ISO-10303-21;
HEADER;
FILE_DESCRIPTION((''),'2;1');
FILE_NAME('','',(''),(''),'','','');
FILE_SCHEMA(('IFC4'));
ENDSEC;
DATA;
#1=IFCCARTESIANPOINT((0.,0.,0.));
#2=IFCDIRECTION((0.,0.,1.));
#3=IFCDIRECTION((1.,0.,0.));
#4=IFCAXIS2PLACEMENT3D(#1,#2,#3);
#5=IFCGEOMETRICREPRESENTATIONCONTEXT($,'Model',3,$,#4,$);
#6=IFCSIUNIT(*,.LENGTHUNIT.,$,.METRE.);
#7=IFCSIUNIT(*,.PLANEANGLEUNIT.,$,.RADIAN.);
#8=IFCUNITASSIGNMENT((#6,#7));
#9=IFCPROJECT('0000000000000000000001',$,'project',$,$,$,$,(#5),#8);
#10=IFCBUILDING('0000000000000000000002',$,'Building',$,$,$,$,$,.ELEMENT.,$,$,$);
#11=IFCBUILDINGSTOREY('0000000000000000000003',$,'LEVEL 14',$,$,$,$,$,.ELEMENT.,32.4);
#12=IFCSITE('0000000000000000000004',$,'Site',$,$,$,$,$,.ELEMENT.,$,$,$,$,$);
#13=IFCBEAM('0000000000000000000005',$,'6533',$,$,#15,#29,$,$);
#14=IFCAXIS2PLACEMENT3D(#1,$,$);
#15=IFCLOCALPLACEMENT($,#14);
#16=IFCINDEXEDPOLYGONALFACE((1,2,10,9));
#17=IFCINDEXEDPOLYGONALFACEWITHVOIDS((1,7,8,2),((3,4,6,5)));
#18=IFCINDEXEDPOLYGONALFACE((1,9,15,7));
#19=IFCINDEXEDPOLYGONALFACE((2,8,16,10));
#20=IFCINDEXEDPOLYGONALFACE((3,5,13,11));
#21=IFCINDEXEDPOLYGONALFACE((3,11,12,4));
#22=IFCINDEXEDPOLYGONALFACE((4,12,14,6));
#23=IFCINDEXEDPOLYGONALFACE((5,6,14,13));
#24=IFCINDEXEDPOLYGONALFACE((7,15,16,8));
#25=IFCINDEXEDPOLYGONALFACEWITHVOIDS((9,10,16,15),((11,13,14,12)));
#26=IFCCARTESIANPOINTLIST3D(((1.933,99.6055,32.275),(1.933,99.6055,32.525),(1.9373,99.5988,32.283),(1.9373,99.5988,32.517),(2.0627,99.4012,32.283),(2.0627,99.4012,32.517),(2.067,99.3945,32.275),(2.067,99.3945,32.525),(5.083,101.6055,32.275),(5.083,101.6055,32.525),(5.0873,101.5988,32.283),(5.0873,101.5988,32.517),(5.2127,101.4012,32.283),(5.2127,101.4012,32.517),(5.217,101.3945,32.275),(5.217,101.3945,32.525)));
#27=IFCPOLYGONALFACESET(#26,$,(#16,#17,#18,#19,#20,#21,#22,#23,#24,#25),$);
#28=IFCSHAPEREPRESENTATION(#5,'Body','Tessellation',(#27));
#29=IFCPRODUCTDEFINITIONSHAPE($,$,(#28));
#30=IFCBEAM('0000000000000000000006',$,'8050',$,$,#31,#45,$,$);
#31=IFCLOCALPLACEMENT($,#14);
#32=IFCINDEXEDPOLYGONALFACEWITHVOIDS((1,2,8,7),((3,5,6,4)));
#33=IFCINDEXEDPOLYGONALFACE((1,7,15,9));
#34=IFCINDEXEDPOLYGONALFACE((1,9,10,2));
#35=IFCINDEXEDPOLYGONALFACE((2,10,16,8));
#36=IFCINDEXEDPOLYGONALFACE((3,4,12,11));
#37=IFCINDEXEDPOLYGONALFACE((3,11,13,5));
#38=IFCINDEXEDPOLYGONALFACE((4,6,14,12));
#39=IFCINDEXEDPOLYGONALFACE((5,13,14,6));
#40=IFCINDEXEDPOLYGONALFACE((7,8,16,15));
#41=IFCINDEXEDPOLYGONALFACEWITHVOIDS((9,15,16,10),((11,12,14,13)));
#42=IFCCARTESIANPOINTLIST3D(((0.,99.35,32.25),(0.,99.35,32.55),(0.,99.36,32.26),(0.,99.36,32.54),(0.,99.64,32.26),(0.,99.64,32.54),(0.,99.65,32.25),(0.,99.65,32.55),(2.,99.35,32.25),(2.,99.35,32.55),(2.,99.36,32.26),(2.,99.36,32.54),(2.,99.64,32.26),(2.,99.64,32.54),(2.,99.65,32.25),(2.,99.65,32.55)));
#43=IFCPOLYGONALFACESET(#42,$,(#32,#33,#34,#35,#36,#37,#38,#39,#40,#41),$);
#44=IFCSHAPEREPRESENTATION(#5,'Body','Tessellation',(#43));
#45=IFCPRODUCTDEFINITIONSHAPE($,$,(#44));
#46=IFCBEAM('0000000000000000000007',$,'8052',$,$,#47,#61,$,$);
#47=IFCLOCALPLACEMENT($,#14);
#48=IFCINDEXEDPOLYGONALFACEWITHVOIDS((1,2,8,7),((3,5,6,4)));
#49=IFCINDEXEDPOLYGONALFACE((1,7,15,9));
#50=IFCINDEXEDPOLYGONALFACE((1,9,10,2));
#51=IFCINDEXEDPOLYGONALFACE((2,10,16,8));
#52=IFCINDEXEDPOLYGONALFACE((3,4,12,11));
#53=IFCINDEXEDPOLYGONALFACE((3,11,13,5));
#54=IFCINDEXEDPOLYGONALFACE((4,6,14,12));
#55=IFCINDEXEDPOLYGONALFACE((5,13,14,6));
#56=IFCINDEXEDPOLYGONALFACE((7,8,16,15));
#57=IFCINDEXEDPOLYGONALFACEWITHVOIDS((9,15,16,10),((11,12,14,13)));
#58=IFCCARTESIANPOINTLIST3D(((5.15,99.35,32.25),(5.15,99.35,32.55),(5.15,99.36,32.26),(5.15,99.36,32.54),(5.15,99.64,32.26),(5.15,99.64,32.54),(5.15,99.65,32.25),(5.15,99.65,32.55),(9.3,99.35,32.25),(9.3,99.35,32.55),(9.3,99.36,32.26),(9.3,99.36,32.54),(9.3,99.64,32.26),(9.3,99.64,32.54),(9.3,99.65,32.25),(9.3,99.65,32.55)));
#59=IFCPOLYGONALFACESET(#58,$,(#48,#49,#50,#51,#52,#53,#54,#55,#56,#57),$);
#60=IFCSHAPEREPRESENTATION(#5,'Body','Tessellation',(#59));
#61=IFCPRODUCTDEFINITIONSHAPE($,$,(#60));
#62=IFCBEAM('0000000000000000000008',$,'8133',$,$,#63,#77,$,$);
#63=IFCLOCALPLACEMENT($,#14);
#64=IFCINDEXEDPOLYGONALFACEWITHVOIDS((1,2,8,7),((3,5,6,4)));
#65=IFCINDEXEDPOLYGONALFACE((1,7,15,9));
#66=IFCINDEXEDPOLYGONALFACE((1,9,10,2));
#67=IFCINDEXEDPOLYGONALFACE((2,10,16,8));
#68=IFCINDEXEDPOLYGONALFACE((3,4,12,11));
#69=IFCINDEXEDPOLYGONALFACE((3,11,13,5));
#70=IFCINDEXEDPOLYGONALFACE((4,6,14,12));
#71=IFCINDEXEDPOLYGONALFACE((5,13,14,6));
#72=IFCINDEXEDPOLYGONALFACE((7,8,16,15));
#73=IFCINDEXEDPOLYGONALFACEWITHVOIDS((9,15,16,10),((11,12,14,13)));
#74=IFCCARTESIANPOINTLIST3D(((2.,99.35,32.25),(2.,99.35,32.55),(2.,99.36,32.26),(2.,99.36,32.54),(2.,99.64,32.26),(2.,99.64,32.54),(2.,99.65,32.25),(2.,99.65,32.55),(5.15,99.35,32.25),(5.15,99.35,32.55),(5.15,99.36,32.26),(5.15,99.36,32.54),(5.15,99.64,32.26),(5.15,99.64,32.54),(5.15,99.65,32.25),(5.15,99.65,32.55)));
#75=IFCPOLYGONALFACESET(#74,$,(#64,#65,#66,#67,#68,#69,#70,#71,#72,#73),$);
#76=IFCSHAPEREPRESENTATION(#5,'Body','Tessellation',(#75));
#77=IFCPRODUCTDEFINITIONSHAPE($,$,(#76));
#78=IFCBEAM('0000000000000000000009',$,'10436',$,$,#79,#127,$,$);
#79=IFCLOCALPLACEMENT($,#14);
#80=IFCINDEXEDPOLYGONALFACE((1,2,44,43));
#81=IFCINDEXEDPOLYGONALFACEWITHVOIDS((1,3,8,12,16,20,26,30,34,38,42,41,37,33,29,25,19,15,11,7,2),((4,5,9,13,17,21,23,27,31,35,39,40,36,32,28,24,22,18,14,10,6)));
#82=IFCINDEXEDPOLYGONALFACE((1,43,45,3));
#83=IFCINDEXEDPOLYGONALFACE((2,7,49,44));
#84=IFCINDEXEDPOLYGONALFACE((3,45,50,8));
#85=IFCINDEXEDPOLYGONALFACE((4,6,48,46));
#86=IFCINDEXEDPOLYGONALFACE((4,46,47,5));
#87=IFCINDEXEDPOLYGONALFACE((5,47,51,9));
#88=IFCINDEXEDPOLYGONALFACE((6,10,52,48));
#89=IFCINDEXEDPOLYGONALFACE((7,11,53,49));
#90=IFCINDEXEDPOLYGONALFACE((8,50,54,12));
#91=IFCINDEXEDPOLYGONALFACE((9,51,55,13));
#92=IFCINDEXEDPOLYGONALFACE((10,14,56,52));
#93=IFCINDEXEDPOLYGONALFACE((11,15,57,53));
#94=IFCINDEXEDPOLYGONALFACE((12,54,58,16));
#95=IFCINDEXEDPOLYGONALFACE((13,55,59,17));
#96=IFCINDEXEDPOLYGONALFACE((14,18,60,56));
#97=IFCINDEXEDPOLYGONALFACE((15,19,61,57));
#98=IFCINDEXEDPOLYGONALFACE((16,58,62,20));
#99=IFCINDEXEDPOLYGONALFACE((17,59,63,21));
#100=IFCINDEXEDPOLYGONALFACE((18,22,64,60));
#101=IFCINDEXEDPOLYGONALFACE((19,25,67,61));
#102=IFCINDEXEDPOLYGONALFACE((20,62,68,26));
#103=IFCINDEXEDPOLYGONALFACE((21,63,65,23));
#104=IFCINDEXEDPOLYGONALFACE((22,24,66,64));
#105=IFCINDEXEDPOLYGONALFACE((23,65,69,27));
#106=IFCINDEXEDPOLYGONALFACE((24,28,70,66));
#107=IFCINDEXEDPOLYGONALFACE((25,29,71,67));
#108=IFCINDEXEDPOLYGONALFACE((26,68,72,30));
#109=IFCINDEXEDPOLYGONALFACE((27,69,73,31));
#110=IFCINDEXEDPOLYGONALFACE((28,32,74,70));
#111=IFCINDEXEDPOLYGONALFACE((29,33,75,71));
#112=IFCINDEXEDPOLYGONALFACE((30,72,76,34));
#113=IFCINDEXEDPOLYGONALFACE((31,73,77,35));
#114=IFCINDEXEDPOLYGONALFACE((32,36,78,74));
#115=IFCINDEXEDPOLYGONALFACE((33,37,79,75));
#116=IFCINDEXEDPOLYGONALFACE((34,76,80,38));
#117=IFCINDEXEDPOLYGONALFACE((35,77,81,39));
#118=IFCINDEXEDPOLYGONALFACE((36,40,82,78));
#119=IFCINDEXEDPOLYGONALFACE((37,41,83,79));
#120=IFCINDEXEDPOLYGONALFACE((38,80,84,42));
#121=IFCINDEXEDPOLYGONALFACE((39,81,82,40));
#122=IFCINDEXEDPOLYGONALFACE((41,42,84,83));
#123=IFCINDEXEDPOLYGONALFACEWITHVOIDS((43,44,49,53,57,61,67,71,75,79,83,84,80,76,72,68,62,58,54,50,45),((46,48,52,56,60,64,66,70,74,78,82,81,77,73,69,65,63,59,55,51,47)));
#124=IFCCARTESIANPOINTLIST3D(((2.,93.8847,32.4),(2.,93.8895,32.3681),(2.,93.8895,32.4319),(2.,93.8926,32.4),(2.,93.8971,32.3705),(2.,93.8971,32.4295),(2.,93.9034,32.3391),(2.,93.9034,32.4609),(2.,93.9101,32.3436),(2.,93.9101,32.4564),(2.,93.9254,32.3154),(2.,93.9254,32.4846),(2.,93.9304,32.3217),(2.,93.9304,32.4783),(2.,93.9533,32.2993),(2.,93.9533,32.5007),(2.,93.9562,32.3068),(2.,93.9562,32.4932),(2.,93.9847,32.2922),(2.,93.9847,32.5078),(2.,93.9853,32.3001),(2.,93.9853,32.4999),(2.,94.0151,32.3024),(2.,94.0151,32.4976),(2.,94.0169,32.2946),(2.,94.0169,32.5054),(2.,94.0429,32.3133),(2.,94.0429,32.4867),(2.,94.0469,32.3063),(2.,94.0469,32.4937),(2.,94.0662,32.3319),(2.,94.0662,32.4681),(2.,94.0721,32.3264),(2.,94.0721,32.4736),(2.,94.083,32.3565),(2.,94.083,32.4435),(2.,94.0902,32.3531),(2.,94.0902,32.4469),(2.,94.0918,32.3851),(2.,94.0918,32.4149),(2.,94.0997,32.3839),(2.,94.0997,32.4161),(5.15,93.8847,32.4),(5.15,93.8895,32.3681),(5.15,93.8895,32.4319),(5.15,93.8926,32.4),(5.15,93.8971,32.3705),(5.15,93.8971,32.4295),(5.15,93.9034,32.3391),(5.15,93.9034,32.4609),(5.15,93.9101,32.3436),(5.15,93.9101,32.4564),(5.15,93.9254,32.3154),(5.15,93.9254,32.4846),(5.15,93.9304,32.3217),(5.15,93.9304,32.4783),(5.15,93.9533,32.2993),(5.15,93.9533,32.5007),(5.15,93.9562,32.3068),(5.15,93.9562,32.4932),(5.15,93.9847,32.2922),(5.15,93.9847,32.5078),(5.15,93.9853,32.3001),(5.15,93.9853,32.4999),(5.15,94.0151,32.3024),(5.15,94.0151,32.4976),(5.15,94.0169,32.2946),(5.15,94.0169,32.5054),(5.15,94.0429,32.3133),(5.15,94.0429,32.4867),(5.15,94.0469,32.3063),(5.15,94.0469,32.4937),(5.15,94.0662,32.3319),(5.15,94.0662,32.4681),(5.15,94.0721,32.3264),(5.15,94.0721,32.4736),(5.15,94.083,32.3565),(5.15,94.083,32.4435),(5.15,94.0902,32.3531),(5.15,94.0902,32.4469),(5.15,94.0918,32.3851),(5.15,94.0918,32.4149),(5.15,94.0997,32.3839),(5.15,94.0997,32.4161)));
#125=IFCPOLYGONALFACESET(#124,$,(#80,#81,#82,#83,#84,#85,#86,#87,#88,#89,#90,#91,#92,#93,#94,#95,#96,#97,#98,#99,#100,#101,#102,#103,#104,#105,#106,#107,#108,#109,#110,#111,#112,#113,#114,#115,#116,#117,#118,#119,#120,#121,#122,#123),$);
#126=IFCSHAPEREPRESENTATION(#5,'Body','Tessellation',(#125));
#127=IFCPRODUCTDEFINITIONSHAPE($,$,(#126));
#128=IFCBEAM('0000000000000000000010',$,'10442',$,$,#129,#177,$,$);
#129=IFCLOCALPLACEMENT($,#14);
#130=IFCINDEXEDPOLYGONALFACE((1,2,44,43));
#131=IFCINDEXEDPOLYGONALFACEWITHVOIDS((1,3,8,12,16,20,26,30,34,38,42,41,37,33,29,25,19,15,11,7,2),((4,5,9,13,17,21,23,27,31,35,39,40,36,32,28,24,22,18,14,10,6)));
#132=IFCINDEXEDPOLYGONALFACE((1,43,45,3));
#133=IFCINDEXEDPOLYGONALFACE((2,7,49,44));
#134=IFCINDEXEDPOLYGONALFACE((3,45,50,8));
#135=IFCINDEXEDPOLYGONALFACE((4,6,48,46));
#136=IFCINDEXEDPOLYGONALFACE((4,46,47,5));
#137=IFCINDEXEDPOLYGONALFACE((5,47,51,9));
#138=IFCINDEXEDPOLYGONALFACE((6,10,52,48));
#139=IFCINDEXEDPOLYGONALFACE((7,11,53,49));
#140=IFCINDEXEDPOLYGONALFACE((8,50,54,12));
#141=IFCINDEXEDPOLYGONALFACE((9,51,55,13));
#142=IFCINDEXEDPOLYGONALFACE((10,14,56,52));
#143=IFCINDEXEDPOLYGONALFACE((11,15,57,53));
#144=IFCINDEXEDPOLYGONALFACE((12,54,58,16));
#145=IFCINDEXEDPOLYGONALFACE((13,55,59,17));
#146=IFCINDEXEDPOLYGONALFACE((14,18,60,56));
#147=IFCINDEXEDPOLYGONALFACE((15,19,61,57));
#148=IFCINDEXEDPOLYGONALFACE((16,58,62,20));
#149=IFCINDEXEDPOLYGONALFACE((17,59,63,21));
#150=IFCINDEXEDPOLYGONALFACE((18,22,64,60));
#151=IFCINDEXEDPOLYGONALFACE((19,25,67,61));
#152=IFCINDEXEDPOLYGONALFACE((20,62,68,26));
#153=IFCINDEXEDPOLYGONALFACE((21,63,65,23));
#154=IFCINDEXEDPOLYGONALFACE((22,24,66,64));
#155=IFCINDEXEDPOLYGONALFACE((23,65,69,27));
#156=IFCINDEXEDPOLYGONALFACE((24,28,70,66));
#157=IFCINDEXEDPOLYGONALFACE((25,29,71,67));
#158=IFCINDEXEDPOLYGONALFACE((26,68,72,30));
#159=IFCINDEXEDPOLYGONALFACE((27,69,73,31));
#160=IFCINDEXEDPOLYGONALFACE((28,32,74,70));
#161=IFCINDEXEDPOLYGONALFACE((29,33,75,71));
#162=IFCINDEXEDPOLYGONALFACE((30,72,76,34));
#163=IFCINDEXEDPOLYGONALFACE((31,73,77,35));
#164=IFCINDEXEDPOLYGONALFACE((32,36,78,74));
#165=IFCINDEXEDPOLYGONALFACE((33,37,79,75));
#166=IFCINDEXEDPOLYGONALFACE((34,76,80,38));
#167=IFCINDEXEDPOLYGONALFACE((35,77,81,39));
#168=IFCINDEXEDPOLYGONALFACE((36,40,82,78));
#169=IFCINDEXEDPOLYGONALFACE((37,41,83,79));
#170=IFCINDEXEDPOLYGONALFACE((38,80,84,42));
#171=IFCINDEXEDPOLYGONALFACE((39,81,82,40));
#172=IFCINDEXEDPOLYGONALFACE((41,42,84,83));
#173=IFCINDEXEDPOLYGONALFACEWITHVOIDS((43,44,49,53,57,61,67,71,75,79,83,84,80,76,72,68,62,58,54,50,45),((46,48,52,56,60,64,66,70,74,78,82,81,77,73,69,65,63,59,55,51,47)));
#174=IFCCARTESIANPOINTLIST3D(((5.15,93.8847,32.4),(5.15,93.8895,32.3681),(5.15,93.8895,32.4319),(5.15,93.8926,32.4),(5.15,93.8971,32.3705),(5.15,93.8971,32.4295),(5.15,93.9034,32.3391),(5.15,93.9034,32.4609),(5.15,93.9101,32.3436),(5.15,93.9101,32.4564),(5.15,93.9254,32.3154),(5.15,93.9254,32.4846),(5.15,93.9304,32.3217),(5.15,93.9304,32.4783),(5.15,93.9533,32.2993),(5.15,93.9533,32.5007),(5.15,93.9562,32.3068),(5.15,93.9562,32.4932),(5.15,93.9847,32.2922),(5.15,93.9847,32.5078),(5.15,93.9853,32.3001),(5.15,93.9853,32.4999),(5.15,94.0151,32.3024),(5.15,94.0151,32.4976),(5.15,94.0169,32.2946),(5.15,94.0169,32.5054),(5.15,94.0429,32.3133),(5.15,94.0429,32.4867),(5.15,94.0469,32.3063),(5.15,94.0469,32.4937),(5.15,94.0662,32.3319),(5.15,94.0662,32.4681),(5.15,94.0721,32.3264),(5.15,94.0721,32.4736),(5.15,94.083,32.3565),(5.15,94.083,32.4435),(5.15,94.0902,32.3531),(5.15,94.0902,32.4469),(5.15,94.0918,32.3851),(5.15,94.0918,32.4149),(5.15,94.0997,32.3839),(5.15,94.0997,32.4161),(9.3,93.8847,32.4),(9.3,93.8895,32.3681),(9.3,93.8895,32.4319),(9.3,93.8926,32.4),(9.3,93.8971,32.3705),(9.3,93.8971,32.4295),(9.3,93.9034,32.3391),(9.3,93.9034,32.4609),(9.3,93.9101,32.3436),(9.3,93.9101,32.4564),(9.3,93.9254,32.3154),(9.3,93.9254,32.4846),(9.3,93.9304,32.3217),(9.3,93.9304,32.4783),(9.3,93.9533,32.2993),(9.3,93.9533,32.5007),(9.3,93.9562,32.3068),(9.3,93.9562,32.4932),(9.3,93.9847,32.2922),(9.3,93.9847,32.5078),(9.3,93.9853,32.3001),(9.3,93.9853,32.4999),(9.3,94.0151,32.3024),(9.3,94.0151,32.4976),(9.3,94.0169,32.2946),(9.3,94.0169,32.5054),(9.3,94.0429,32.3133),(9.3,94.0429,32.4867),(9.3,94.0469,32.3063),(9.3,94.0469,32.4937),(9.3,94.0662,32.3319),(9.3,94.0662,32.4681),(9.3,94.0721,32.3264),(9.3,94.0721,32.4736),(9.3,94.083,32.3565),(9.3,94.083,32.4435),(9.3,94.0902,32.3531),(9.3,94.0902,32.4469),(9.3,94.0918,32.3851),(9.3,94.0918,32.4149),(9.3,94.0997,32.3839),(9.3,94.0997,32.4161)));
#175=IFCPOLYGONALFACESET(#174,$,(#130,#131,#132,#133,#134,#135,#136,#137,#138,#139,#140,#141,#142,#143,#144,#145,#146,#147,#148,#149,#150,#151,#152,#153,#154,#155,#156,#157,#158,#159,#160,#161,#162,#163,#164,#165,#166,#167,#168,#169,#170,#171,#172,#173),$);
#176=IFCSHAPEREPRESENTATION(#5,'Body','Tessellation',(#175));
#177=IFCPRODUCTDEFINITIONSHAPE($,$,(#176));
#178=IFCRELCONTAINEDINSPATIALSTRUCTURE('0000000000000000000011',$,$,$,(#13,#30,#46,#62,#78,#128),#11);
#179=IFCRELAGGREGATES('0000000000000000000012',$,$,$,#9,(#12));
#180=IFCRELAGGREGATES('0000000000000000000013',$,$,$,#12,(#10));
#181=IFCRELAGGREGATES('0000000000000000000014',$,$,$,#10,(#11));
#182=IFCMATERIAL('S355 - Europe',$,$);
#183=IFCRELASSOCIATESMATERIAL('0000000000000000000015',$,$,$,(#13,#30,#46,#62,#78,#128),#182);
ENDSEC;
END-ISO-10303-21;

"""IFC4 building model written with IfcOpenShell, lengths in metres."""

from ifc_helpers import new_model, si_unit, frame, origin_with_axes, origin_2d_with_axis, place, context, project, spatial, hollow_rectangle, hollow_circle, extrude, material, material_profile, profile_set, profile_usage, element, save


model = new_model("IFC4")

# Units and contexts
model_context = context("Model", 3, world=origin_with_axes())
ifc_project = project(units=[si_unit("LENGTHUNIT", "METRE"), si_unit("PLANEANGLEUNIT", "RADIAN")], contexts=[model_context])

# Site, building, storey
site = spatial("IfcSite", under=ifc_project, Name="Site", CompositionType="ELEMENT")
building = spatial("IfcBuilding", under=site, Name="Building", CompositionType="ELEMENT")
storey = spatial("IfcBuildingStorey", under=building, Name="LEVEL 14", CompositionType="ELEMENT", Elevation=32.4)

# Shared definitions
ifc_material = material(Name="S355 - Europe")

# Beams
ifc_material_profile_1 = material_profile(ifc_material, hollow_rectangle(XDim=0.25, YDim=0.25, WallThickness=0.008, at=origin_2d_with_axis()))
ifc_profile_set_1 = profile_set([ifc_material_profile_1])
ifc_profile_usage_1 = profile_usage(ifc_profile_set_1, cardinal=10)
beam_1_placement = place(None, frame((2.0, 99.5, 32.4), z_axis=(0.844213, 0.536008, 0.0), x_axis=(-0.536008, 0.844213, 0.0)))
element("IfcBeam", 1, at=beam_1_placement, inside=storey, material=ifc_profile_usage_1, Name="6533", context=model_context, shape_type="SweptSolid", body=[
    extrude(hollow_rectangle(XDim=0.25, YDim=0.25, WallThickness=0.008, at=origin_2d_with_axis()), origin_with_axes(), (0.0, 0.0, 1.0), 3.7313),
])
ifc_material_profile_2 = material_profile(ifc_material, hollow_rectangle(XDim=0.3, YDim=0.3, WallThickness=0.01, at=origin_2d_with_axis()))
ifc_profile_set_2 = profile_set([ifc_material_profile_2])
ifc_profile_usage_2 = profile_usage(ifc_profile_set_2, cardinal=10)
beam_2_placement = place(None, frame((0.0, 99.5, 32.4), z_axis=(1.0, 0.0, 0.0), x_axis=(0.0, 1.0, 0.0)))
element("IfcBeam", 2, at=beam_2_placement, inside=storey, material=ifc_profile_usage_2, Name="8050", context=model_context, shape_type="SweptSolid", body=[
    extrude(hollow_rectangle(XDim=0.3, YDim=0.3, WallThickness=0.01, at=origin_2d_with_axis()), origin_with_axes(), (0.0, 0.0, 1.0), 2.0),
])
ifc_material_profile_3 = material_profile(ifc_material, hollow_rectangle(XDim=0.3, YDim=0.3, WallThickness=0.01, at=origin_2d_with_axis()))
ifc_profile_set_3 = profile_set([ifc_material_profile_3])
ifc_profile_usage_3 = profile_usage(ifc_profile_set_3, cardinal=10)
beam_3_placement = place(None, frame((5.15, 99.5, 32.4), z_axis=(1.0, 0.0, 0.0), x_axis=(0.0, 1.0, 0.0)))
element("IfcBeam", 3, at=beam_3_placement, inside=storey, material=ifc_profile_usage_3, Name="8052", context=model_context, shape_type="SweptSolid", body=[
    extrude(hollow_rectangle(XDim=0.3, YDim=0.3, WallThickness=0.01, at=origin_2d_with_axis()), origin_with_axes(), (0.0, 0.0, 1.0), 4.15),
])
ifc_material_profile_4 = material_profile(ifc_material, hollow_rectangle(XDim=0.3, YDim=0.3, WallThickness=0.01, at=origin_2d_with_axis()))
ifc_profile_set_4 = profile_set([ifc_material_profile_4])
ifc_profile_usage_4 = profile_usage(ifc_profile_set_4, cardinal=10)
beam_4_placement = place(None, frame((2.0, 99.5, 32.4), z_axis=(1.0, 0.0, 0.0), x_axis=(0.0, 1.0, 0.0)))
element("IfcBeam", 4, at=beam_4_placement, inside=storey, material=ifc_profile_usage_4, Name="8133", context=model_context, shape_type="SweptSolid", body=[
    extrude(hollow_rectangle(XDim=0.3, YDim=0.3, WallThickness=0.01, at=origin_2d_with_axis()), origin_with_axes(), (0.0, 0.0, 1.0), 3.15),
])
ifc_material_profile_5 = material_profile(ifc_material, hollow_circle(Radius=0.1081, WallThickness=0.008, at=origin_2d_with_axis()))
ifc_profile_set_5 = profile_set([ifc_material_profile_5])
ifc_profile_usage_5 = profile_usage(ifc_profile_set_5, cardinal=10)
beam_5_placement = place(None, frame((5.15, 93.9928, 32.4), z_axis=(-1.0, 0.0, 0.0), x_axis=(0.0, -1.0, 0.0)))
element("IfcBeam", 5, at=beam_5_placement, inside=storey, material=ifc_profile_usage_5, Name="10436", context=model_context, shape_type="SweptSolid", body=[
    extrude(hollow_circle(Radius=0.1081, WallThickness=0.008, at=origin_2d_with_axis()), origin_with_axes(), (0.0, 0.0, 1.0), 3.15),
])
ifc_material_profile_6 = material_profile(ifc_material, hollow_circle(Radius=0.1081, WallThickness=0.008, at=origin_2d_with_axis()))
ifc_profile_set_6 = profile_set([ifc_material_profile_6])
ifc_profile_usage_6 = profile_usage(ifc_profile_set_6, cardinal=10)
beam_6_placement = place(None, frame((9.3, 93.9928, 32.4), z_axis=(-1.0, 0.0, 0.0), x_axis=(0.0, -1.0, 0.0)))
element("IfcBeam", 6, at=beam_6_placement, inside=storey, material=ifc_profile_usage_6, Name="10442", context=model_context, shape_type="SweptSolid", body=[
    extrude(hollow_circle(Radius=0.1081, WallThickness=0.008, at=origin_2d_with_axis()), origin_with_axes(), (0.0, 0.0, 1.0), 4.15),
])

save(model, "model.ifc")
